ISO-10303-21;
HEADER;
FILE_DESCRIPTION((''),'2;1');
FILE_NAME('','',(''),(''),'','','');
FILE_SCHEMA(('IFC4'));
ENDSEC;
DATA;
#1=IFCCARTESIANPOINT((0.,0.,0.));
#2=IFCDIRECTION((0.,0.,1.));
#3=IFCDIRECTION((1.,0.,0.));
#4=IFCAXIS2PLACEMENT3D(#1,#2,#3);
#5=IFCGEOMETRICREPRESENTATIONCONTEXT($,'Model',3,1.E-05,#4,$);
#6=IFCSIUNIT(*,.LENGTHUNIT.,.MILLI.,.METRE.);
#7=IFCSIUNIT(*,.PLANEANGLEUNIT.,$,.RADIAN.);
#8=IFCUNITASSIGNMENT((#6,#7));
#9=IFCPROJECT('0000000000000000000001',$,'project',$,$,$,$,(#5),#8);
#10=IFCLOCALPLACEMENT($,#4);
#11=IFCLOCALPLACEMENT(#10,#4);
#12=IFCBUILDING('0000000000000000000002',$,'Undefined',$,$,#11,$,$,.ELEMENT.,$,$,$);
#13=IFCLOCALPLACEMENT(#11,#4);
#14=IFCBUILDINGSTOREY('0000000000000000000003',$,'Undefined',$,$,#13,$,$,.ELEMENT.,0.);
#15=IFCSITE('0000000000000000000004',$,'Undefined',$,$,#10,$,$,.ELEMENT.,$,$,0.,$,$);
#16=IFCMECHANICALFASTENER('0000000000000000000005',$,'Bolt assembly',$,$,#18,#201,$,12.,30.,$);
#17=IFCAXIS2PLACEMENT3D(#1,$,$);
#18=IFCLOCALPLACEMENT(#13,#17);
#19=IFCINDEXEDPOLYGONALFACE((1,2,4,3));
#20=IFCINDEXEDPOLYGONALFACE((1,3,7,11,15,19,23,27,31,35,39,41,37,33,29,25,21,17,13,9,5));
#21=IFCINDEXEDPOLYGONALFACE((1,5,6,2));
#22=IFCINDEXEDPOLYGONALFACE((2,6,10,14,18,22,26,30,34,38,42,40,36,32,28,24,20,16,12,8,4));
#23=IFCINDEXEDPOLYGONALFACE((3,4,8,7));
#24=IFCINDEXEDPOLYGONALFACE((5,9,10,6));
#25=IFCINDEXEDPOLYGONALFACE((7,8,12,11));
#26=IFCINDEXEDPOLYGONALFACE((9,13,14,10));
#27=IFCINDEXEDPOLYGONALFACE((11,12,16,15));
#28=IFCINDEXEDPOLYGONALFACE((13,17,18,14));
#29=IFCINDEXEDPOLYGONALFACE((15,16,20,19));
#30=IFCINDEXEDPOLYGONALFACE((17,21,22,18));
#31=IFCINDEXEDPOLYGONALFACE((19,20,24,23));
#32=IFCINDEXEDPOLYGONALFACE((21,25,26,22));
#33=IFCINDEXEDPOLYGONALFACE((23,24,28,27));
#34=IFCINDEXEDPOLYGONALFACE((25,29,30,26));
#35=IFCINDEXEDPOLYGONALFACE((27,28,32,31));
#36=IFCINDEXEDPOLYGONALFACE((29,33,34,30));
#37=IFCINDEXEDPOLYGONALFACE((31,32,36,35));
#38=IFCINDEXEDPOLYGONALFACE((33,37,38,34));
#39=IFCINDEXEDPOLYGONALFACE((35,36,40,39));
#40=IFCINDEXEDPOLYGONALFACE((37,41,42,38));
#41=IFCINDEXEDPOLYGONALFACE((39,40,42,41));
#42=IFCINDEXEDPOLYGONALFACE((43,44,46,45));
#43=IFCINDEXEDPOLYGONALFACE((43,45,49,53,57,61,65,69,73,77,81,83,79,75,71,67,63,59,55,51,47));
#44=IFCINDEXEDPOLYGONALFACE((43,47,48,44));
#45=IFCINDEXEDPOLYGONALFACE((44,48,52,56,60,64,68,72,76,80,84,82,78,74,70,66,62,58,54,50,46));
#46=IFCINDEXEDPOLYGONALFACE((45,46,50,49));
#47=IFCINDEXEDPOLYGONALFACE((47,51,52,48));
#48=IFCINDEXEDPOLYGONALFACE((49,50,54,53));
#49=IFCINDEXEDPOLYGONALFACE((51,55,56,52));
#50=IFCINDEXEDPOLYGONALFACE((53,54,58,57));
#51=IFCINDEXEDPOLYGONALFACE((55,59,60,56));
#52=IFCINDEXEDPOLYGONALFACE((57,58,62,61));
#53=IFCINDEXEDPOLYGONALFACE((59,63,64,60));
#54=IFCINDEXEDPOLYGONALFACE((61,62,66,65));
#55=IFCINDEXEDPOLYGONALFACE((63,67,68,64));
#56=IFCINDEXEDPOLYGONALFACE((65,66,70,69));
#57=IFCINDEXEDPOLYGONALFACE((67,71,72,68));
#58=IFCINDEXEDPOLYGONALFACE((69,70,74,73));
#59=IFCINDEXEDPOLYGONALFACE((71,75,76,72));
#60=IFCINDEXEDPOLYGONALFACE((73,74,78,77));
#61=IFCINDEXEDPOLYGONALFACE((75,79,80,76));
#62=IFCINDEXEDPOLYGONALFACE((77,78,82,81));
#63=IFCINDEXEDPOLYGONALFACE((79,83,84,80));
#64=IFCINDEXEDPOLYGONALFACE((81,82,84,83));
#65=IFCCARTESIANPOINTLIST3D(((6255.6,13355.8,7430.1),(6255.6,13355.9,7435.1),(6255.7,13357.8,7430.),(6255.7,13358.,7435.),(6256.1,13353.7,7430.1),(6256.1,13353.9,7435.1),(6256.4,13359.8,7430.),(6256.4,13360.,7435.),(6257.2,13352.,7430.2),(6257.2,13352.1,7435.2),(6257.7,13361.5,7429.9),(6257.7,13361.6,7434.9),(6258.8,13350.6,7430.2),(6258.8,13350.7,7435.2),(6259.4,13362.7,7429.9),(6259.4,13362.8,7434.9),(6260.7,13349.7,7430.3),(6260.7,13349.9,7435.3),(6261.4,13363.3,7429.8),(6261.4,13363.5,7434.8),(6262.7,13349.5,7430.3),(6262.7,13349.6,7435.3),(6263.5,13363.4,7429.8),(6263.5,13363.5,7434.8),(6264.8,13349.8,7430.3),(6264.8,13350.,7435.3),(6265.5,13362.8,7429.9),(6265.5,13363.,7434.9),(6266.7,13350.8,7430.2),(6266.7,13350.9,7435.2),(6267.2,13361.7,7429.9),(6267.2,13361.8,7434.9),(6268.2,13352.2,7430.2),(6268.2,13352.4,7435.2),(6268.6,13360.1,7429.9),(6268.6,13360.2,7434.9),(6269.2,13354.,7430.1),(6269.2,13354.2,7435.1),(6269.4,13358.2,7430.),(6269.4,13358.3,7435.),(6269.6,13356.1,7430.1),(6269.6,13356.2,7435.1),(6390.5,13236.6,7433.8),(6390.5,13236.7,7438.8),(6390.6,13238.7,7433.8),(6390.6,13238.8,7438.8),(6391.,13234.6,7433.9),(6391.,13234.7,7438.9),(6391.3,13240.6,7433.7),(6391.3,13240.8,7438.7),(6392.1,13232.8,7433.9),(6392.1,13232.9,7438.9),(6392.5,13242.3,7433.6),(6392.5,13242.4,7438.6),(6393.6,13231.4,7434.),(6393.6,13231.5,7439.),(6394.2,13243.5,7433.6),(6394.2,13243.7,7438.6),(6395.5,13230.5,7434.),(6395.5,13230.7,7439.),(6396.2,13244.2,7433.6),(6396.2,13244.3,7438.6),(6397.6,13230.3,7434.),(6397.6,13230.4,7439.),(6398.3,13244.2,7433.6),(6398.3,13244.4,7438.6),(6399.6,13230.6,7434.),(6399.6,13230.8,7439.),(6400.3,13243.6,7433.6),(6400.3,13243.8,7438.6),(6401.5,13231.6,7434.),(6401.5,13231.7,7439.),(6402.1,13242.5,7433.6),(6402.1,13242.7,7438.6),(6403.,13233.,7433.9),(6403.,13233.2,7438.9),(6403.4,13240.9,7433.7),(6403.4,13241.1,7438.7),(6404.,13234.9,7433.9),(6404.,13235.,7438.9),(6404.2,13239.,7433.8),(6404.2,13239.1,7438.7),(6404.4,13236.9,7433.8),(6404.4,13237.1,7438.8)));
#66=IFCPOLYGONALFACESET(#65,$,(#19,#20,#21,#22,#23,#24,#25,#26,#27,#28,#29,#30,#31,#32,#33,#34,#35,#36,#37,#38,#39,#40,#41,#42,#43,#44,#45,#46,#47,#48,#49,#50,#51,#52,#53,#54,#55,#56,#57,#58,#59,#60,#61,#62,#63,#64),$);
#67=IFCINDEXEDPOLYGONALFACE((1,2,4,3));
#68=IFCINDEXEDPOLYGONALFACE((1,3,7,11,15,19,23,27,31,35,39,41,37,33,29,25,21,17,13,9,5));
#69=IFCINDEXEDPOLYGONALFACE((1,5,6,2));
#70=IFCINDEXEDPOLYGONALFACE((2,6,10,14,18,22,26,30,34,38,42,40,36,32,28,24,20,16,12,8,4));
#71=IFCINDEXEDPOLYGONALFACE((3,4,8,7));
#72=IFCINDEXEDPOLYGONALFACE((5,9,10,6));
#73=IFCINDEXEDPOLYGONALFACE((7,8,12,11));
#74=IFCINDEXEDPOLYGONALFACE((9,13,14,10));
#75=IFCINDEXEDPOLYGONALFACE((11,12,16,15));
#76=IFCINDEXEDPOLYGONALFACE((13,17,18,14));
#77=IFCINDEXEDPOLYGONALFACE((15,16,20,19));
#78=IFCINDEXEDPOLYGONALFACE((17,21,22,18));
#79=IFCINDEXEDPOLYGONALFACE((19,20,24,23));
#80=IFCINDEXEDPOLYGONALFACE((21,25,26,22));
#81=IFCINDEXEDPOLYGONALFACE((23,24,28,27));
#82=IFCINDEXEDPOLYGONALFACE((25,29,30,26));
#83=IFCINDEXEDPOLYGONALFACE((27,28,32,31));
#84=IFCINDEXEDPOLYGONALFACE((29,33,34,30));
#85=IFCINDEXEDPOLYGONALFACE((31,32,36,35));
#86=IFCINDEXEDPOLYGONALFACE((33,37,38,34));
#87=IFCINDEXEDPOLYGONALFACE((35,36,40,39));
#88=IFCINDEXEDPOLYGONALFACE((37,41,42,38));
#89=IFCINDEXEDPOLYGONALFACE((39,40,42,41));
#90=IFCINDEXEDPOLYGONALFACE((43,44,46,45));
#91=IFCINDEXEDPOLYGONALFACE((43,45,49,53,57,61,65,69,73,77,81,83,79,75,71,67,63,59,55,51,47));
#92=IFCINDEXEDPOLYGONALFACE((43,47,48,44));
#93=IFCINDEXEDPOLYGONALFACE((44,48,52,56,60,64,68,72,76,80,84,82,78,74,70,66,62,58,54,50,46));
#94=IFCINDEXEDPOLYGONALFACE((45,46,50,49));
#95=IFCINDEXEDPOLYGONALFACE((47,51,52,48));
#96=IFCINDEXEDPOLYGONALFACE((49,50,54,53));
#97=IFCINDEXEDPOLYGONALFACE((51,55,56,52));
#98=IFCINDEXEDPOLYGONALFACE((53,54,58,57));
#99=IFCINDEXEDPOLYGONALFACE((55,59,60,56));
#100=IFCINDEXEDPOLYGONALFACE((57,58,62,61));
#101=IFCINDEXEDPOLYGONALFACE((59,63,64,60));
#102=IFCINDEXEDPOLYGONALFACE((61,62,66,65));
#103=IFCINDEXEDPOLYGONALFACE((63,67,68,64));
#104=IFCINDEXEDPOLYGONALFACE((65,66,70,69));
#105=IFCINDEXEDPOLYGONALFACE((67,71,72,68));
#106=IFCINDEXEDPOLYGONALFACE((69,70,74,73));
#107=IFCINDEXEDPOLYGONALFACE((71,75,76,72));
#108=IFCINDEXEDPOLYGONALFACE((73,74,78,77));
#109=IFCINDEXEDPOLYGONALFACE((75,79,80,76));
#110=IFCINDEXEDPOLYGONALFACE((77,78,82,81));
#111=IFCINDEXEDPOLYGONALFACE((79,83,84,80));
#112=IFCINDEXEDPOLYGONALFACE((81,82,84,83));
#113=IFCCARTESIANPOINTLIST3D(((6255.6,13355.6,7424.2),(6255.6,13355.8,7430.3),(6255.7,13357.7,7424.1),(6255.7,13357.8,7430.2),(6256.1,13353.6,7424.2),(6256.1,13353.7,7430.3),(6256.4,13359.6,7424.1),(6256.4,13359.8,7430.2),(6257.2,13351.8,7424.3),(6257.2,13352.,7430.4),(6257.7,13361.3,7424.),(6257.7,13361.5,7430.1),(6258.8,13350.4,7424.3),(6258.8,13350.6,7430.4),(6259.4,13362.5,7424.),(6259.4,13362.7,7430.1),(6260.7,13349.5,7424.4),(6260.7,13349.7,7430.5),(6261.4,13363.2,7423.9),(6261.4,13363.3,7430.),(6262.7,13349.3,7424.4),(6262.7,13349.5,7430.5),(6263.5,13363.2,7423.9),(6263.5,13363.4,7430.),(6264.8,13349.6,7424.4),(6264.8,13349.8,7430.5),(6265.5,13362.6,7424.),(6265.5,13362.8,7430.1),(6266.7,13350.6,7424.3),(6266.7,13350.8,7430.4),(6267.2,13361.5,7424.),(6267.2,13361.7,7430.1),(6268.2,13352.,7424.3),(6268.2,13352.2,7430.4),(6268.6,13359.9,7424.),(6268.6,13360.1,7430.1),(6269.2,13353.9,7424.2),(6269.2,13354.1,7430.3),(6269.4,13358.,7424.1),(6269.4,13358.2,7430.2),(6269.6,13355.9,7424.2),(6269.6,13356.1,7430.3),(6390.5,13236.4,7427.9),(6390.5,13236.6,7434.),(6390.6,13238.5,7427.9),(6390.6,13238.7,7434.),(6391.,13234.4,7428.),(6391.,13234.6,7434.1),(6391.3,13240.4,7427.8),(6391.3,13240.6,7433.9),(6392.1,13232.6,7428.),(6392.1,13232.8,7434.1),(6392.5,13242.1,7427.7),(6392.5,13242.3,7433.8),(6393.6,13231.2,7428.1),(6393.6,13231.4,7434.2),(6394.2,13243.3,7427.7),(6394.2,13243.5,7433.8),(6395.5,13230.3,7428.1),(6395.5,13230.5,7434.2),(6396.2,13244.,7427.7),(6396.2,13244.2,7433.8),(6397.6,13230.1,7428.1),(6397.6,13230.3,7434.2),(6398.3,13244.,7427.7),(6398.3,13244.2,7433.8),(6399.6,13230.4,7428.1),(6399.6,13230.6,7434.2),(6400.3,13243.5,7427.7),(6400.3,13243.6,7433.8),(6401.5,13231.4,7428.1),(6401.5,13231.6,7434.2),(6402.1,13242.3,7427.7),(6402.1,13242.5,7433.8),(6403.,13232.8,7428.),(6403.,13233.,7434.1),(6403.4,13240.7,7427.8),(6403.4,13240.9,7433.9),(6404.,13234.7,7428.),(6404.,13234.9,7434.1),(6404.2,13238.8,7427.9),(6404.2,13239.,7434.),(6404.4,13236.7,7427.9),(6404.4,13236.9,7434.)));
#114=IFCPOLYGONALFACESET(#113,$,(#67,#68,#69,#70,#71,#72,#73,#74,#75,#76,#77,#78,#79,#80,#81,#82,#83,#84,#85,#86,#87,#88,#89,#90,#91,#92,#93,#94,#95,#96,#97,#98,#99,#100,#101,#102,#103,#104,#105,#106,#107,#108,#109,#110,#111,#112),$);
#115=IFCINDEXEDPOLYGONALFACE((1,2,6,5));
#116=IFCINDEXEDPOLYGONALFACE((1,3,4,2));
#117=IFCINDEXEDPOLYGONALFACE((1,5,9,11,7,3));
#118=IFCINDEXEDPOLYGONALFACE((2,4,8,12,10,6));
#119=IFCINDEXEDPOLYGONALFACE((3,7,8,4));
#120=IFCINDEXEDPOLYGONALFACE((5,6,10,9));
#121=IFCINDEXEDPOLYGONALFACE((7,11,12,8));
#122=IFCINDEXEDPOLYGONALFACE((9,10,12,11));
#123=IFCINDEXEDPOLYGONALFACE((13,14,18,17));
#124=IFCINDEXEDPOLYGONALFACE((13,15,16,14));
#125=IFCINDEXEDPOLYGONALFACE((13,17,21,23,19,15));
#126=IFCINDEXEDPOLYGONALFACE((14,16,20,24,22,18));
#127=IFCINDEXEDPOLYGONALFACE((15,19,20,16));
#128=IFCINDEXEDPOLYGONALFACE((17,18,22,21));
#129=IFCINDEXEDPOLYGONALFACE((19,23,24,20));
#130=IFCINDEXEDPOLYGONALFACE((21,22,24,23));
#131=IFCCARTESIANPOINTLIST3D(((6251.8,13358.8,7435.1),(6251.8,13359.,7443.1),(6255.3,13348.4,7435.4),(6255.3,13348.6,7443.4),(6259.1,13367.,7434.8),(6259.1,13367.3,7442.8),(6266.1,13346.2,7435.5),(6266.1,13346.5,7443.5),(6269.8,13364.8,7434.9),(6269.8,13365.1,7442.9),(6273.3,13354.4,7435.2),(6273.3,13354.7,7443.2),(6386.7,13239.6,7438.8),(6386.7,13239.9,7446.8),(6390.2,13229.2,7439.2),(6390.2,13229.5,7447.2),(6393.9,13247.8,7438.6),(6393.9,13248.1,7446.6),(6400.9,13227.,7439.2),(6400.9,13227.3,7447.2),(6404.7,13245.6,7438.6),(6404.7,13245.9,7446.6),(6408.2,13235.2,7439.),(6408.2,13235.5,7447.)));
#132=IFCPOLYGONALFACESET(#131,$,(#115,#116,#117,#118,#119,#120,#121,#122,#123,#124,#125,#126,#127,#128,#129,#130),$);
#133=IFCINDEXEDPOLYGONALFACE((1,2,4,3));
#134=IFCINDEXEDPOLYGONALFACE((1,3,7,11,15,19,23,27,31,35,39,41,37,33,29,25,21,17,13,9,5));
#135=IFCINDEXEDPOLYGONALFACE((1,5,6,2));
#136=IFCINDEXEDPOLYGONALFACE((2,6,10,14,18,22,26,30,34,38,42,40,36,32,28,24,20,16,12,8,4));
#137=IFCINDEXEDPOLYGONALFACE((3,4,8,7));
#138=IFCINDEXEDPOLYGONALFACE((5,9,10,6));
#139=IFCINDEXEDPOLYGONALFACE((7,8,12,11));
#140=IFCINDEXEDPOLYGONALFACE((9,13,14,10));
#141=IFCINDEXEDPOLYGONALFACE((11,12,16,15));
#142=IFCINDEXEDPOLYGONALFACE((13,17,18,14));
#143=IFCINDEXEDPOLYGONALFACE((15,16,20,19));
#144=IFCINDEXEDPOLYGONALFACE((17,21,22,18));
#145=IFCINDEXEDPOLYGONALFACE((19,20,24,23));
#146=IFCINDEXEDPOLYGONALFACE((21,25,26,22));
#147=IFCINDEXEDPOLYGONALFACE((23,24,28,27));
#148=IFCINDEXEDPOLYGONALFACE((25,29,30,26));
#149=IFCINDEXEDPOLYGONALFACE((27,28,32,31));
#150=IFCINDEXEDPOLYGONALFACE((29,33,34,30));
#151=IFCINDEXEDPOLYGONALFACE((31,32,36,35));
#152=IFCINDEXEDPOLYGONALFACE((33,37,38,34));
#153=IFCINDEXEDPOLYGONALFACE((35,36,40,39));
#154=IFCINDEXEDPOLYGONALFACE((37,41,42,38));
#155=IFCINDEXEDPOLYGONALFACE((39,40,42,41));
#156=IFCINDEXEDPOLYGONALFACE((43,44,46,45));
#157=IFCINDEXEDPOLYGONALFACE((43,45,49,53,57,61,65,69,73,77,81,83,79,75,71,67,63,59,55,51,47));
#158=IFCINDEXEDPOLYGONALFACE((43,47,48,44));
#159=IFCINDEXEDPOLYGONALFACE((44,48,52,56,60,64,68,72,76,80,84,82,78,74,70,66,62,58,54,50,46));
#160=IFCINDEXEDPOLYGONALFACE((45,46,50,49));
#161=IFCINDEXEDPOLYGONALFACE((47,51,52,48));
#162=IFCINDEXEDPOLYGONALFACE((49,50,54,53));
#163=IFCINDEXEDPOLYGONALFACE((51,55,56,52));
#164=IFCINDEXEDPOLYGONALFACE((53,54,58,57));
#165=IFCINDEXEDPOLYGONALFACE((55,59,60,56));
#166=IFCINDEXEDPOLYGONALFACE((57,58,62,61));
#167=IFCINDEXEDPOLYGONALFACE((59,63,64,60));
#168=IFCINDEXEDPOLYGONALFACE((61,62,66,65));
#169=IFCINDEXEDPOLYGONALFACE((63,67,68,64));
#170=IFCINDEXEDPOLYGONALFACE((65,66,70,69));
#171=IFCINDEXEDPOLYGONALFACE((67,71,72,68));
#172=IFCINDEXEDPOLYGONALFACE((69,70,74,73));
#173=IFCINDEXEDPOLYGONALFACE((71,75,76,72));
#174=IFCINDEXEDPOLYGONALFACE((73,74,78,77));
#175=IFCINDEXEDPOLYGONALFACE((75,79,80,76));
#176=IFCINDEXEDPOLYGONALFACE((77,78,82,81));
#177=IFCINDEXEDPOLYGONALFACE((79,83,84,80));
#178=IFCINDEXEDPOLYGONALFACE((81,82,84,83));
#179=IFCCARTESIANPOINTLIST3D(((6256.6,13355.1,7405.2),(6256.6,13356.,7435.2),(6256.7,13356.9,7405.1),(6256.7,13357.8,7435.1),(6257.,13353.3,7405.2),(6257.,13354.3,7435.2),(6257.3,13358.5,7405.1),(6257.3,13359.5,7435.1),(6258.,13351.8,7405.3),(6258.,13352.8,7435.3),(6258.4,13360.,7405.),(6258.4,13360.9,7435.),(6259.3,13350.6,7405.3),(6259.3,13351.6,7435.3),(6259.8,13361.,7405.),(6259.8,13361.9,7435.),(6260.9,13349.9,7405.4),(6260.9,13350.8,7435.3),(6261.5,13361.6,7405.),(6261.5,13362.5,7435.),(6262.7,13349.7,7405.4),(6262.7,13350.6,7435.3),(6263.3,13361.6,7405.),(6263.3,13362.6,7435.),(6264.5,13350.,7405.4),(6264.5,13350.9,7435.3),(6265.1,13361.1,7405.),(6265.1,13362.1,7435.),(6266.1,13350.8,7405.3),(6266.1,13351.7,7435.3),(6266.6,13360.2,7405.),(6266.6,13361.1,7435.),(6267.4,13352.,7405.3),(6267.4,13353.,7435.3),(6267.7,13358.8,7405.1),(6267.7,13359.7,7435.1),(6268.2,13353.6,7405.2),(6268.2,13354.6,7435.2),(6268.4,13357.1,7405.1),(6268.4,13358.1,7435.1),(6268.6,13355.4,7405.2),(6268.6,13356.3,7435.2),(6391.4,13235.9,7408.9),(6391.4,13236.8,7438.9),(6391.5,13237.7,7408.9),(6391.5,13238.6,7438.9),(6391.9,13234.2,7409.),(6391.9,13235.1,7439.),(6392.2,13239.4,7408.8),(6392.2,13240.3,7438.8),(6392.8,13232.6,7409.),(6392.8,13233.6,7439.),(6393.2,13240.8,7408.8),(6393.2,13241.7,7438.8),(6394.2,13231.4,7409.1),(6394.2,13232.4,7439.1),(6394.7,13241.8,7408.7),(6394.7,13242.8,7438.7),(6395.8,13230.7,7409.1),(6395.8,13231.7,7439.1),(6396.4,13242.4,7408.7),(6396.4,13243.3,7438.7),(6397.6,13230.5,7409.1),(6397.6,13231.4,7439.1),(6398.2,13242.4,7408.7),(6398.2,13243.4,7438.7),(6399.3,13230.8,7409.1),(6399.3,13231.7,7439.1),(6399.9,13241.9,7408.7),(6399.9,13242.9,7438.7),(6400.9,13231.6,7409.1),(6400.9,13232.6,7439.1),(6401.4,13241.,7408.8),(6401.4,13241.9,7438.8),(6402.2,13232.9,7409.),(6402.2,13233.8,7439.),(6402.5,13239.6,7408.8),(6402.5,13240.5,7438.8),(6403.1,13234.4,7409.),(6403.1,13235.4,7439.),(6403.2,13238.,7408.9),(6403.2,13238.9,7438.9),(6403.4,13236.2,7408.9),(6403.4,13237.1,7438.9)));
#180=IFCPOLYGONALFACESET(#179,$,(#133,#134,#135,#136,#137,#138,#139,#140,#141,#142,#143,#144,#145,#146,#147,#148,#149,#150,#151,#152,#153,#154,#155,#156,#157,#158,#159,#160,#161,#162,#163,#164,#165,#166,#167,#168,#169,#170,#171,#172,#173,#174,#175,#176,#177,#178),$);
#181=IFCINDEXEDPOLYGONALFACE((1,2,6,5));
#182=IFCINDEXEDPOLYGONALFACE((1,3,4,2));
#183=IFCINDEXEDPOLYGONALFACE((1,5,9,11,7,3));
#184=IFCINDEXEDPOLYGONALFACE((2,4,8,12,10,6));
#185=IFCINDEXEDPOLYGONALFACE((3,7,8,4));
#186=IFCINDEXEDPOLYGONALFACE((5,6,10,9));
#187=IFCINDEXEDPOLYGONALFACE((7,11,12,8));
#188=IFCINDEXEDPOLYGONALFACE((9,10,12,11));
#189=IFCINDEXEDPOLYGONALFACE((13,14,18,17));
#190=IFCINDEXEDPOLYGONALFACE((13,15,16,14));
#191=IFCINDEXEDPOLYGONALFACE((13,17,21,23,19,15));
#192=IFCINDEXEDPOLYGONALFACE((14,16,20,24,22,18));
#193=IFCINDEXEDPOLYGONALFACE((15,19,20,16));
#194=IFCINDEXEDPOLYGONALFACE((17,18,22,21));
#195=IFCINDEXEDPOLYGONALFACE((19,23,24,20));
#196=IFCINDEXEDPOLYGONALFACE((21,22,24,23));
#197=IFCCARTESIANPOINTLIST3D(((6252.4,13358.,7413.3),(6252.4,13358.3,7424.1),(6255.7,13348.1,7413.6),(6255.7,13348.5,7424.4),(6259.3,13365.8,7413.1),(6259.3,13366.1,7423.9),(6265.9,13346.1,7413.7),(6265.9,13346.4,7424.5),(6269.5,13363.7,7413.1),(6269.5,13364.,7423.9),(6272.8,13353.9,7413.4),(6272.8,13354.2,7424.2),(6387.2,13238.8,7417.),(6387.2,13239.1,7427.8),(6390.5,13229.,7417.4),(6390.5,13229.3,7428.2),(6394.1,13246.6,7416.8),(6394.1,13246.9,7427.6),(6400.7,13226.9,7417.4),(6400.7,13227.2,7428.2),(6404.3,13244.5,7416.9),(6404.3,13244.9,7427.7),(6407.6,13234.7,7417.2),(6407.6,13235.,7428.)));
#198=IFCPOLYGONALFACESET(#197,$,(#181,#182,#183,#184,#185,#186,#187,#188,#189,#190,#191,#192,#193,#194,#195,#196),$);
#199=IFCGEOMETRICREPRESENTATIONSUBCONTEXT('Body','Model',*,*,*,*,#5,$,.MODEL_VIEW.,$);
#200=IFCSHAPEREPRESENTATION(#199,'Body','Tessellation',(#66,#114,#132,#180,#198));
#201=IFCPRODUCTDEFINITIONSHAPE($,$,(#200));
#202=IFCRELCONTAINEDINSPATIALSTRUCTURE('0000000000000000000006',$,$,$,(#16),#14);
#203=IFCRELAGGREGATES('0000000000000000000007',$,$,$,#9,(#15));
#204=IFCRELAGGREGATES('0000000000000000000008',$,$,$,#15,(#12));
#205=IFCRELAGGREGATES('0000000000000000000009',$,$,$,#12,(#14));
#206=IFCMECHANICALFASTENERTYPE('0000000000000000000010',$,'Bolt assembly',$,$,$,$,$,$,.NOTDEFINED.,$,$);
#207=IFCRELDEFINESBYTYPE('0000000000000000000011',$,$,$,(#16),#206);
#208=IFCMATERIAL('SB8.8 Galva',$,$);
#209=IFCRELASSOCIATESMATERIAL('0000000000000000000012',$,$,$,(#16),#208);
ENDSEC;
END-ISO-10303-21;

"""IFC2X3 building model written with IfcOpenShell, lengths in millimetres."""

from ifc_helpers import new_model, si_unit, frame, origin_with_axes, origin_2d_with_axis, place, context, subcontext, project, spatial, polyline, circle, outline, extrude, source, transform, mapped, material, type_object, element, save


model = new_model("IFC2X3")

# Units and contexts
model_context = context("Model", 3, precision=1e-05, world=origin_with_axes())
body_context = subcontext(model_context, "Body", "Model", "MODEL_VIEW")
ifc_project = project(units=[si_unit("LENGTHUNIT", "METRE", prefix="MILLI"), si_unit("PLANEANGLEUNIT", "RADIAN")], contexts=[model_context])

# Site, building, storey
site_placement = place(None, origin_with_axes())
site = spatial("IfcSite", under=ifc_project, at=site_placement, Name="Undefined", CompositionType="ELEMENT", RefElevation=0.0)
building_placement = place(site_placement, origin_with_axes())
building = spatial("IfcBuilding", under=site, at=building_placement, Name="Undefined", CompositionType="ELEMENT")
storey_placement = place(building_placement, origin_with_axes())
storey = spatial("IfcBuildingStorey", under=building, at=storey_placement, Name="Undefined", CompositionType="ELEMENT", Elevation=0.0)

# Mechanical fastener
mechanical_fastener_type = type_object("IfcMechanicalFastenerType", Name="Bolt assembly")
ifc_material_1 = material(Name="SB8.8 Galva")
shared_shape_1 = source(origin_with_axes(), body_context, "Body", "SweptSolid", [
    extrude(circle(Radius=7.0, at=origin_2d_with_axis()), frame((0.0, -4.9, 0.0), z_axis=(0.0, 1.0, 0.0), x_axis=(1.0, 0.0, 0.0)), (0.0, 0.0, 1.0), 5.0),
    extrude(circle(Radius=7.0, at=origin_2d_with_axis()), frame((0.0, -0.1, 0.0), z_axis=(0.0, 1.0, 0.0), x_axis=(1.0, 0.0, 0.0)), (0.0, 0.0, 1.0), 6.1),
    extrude(outline(polyline([(11.0, 0.0), (5.5, 9.5), (-5.5, 9.5), (-11.0, 0.0), (-5.5, -9.5), (5.5, -9.5), (11.0, 0.0)])), frame((0.0, -13.0, 0.0), z_axis=(0.0, 1.0, 0.0), x_axis=(1.0, 0.0, 0.0)), (0.0, 0.0, 1.0), 8.0),
    extrude(circle(Radius=6.0, at=origin_2d_with_axis()), frame((0.0, -5.0, 0.0), z_axis=(0.0, 1.0, 0.0), x_axis=(1.0, 0.0, 0.0)), (0.0, 0.0, 1.0), 30.0),
    extrude(outline(polyline([(10.4, 0.0), (5.2, 9.0), (-5.2, 9.0), (-10.4, 0.0), (-5.2, -9.0), (5.2, -9.0), (10.4, 0.0)])), frame((0.0, 6.0, 0.0), z_axis=(0.0, 1.0, 0.0), x_axis=(1.0, 0.0, 0.0)), (0.0, 0.0, 1.0), 10.8),
])
mechanical_fastener_1_placement = place(storey_placement, frame((6330.0, 13296.9, 7432.0), z_axis=(-0.749103, 0.662127, -0.020808), x_axis=(0.662454, 0.748733, -0.02353)))
element("IfcMechanicalFastener", 1, at=mechanical_fastener_1_placement, inside=storey, type_object=mechanical_fastener_type, material=ifc_material_1, Name="Bolt assembly", NominalDiameter=12.0, NominalLength=30.0, context=body_context, shape_type="MappedRepresentation", body=[
    mapped(shared_shape_1, transform((0.0, 0.0, -90.0))),
    mapped(shared_shape_1, transform((0.0, 0.0, 90.0))),
])

save(model, "model.ifc")
